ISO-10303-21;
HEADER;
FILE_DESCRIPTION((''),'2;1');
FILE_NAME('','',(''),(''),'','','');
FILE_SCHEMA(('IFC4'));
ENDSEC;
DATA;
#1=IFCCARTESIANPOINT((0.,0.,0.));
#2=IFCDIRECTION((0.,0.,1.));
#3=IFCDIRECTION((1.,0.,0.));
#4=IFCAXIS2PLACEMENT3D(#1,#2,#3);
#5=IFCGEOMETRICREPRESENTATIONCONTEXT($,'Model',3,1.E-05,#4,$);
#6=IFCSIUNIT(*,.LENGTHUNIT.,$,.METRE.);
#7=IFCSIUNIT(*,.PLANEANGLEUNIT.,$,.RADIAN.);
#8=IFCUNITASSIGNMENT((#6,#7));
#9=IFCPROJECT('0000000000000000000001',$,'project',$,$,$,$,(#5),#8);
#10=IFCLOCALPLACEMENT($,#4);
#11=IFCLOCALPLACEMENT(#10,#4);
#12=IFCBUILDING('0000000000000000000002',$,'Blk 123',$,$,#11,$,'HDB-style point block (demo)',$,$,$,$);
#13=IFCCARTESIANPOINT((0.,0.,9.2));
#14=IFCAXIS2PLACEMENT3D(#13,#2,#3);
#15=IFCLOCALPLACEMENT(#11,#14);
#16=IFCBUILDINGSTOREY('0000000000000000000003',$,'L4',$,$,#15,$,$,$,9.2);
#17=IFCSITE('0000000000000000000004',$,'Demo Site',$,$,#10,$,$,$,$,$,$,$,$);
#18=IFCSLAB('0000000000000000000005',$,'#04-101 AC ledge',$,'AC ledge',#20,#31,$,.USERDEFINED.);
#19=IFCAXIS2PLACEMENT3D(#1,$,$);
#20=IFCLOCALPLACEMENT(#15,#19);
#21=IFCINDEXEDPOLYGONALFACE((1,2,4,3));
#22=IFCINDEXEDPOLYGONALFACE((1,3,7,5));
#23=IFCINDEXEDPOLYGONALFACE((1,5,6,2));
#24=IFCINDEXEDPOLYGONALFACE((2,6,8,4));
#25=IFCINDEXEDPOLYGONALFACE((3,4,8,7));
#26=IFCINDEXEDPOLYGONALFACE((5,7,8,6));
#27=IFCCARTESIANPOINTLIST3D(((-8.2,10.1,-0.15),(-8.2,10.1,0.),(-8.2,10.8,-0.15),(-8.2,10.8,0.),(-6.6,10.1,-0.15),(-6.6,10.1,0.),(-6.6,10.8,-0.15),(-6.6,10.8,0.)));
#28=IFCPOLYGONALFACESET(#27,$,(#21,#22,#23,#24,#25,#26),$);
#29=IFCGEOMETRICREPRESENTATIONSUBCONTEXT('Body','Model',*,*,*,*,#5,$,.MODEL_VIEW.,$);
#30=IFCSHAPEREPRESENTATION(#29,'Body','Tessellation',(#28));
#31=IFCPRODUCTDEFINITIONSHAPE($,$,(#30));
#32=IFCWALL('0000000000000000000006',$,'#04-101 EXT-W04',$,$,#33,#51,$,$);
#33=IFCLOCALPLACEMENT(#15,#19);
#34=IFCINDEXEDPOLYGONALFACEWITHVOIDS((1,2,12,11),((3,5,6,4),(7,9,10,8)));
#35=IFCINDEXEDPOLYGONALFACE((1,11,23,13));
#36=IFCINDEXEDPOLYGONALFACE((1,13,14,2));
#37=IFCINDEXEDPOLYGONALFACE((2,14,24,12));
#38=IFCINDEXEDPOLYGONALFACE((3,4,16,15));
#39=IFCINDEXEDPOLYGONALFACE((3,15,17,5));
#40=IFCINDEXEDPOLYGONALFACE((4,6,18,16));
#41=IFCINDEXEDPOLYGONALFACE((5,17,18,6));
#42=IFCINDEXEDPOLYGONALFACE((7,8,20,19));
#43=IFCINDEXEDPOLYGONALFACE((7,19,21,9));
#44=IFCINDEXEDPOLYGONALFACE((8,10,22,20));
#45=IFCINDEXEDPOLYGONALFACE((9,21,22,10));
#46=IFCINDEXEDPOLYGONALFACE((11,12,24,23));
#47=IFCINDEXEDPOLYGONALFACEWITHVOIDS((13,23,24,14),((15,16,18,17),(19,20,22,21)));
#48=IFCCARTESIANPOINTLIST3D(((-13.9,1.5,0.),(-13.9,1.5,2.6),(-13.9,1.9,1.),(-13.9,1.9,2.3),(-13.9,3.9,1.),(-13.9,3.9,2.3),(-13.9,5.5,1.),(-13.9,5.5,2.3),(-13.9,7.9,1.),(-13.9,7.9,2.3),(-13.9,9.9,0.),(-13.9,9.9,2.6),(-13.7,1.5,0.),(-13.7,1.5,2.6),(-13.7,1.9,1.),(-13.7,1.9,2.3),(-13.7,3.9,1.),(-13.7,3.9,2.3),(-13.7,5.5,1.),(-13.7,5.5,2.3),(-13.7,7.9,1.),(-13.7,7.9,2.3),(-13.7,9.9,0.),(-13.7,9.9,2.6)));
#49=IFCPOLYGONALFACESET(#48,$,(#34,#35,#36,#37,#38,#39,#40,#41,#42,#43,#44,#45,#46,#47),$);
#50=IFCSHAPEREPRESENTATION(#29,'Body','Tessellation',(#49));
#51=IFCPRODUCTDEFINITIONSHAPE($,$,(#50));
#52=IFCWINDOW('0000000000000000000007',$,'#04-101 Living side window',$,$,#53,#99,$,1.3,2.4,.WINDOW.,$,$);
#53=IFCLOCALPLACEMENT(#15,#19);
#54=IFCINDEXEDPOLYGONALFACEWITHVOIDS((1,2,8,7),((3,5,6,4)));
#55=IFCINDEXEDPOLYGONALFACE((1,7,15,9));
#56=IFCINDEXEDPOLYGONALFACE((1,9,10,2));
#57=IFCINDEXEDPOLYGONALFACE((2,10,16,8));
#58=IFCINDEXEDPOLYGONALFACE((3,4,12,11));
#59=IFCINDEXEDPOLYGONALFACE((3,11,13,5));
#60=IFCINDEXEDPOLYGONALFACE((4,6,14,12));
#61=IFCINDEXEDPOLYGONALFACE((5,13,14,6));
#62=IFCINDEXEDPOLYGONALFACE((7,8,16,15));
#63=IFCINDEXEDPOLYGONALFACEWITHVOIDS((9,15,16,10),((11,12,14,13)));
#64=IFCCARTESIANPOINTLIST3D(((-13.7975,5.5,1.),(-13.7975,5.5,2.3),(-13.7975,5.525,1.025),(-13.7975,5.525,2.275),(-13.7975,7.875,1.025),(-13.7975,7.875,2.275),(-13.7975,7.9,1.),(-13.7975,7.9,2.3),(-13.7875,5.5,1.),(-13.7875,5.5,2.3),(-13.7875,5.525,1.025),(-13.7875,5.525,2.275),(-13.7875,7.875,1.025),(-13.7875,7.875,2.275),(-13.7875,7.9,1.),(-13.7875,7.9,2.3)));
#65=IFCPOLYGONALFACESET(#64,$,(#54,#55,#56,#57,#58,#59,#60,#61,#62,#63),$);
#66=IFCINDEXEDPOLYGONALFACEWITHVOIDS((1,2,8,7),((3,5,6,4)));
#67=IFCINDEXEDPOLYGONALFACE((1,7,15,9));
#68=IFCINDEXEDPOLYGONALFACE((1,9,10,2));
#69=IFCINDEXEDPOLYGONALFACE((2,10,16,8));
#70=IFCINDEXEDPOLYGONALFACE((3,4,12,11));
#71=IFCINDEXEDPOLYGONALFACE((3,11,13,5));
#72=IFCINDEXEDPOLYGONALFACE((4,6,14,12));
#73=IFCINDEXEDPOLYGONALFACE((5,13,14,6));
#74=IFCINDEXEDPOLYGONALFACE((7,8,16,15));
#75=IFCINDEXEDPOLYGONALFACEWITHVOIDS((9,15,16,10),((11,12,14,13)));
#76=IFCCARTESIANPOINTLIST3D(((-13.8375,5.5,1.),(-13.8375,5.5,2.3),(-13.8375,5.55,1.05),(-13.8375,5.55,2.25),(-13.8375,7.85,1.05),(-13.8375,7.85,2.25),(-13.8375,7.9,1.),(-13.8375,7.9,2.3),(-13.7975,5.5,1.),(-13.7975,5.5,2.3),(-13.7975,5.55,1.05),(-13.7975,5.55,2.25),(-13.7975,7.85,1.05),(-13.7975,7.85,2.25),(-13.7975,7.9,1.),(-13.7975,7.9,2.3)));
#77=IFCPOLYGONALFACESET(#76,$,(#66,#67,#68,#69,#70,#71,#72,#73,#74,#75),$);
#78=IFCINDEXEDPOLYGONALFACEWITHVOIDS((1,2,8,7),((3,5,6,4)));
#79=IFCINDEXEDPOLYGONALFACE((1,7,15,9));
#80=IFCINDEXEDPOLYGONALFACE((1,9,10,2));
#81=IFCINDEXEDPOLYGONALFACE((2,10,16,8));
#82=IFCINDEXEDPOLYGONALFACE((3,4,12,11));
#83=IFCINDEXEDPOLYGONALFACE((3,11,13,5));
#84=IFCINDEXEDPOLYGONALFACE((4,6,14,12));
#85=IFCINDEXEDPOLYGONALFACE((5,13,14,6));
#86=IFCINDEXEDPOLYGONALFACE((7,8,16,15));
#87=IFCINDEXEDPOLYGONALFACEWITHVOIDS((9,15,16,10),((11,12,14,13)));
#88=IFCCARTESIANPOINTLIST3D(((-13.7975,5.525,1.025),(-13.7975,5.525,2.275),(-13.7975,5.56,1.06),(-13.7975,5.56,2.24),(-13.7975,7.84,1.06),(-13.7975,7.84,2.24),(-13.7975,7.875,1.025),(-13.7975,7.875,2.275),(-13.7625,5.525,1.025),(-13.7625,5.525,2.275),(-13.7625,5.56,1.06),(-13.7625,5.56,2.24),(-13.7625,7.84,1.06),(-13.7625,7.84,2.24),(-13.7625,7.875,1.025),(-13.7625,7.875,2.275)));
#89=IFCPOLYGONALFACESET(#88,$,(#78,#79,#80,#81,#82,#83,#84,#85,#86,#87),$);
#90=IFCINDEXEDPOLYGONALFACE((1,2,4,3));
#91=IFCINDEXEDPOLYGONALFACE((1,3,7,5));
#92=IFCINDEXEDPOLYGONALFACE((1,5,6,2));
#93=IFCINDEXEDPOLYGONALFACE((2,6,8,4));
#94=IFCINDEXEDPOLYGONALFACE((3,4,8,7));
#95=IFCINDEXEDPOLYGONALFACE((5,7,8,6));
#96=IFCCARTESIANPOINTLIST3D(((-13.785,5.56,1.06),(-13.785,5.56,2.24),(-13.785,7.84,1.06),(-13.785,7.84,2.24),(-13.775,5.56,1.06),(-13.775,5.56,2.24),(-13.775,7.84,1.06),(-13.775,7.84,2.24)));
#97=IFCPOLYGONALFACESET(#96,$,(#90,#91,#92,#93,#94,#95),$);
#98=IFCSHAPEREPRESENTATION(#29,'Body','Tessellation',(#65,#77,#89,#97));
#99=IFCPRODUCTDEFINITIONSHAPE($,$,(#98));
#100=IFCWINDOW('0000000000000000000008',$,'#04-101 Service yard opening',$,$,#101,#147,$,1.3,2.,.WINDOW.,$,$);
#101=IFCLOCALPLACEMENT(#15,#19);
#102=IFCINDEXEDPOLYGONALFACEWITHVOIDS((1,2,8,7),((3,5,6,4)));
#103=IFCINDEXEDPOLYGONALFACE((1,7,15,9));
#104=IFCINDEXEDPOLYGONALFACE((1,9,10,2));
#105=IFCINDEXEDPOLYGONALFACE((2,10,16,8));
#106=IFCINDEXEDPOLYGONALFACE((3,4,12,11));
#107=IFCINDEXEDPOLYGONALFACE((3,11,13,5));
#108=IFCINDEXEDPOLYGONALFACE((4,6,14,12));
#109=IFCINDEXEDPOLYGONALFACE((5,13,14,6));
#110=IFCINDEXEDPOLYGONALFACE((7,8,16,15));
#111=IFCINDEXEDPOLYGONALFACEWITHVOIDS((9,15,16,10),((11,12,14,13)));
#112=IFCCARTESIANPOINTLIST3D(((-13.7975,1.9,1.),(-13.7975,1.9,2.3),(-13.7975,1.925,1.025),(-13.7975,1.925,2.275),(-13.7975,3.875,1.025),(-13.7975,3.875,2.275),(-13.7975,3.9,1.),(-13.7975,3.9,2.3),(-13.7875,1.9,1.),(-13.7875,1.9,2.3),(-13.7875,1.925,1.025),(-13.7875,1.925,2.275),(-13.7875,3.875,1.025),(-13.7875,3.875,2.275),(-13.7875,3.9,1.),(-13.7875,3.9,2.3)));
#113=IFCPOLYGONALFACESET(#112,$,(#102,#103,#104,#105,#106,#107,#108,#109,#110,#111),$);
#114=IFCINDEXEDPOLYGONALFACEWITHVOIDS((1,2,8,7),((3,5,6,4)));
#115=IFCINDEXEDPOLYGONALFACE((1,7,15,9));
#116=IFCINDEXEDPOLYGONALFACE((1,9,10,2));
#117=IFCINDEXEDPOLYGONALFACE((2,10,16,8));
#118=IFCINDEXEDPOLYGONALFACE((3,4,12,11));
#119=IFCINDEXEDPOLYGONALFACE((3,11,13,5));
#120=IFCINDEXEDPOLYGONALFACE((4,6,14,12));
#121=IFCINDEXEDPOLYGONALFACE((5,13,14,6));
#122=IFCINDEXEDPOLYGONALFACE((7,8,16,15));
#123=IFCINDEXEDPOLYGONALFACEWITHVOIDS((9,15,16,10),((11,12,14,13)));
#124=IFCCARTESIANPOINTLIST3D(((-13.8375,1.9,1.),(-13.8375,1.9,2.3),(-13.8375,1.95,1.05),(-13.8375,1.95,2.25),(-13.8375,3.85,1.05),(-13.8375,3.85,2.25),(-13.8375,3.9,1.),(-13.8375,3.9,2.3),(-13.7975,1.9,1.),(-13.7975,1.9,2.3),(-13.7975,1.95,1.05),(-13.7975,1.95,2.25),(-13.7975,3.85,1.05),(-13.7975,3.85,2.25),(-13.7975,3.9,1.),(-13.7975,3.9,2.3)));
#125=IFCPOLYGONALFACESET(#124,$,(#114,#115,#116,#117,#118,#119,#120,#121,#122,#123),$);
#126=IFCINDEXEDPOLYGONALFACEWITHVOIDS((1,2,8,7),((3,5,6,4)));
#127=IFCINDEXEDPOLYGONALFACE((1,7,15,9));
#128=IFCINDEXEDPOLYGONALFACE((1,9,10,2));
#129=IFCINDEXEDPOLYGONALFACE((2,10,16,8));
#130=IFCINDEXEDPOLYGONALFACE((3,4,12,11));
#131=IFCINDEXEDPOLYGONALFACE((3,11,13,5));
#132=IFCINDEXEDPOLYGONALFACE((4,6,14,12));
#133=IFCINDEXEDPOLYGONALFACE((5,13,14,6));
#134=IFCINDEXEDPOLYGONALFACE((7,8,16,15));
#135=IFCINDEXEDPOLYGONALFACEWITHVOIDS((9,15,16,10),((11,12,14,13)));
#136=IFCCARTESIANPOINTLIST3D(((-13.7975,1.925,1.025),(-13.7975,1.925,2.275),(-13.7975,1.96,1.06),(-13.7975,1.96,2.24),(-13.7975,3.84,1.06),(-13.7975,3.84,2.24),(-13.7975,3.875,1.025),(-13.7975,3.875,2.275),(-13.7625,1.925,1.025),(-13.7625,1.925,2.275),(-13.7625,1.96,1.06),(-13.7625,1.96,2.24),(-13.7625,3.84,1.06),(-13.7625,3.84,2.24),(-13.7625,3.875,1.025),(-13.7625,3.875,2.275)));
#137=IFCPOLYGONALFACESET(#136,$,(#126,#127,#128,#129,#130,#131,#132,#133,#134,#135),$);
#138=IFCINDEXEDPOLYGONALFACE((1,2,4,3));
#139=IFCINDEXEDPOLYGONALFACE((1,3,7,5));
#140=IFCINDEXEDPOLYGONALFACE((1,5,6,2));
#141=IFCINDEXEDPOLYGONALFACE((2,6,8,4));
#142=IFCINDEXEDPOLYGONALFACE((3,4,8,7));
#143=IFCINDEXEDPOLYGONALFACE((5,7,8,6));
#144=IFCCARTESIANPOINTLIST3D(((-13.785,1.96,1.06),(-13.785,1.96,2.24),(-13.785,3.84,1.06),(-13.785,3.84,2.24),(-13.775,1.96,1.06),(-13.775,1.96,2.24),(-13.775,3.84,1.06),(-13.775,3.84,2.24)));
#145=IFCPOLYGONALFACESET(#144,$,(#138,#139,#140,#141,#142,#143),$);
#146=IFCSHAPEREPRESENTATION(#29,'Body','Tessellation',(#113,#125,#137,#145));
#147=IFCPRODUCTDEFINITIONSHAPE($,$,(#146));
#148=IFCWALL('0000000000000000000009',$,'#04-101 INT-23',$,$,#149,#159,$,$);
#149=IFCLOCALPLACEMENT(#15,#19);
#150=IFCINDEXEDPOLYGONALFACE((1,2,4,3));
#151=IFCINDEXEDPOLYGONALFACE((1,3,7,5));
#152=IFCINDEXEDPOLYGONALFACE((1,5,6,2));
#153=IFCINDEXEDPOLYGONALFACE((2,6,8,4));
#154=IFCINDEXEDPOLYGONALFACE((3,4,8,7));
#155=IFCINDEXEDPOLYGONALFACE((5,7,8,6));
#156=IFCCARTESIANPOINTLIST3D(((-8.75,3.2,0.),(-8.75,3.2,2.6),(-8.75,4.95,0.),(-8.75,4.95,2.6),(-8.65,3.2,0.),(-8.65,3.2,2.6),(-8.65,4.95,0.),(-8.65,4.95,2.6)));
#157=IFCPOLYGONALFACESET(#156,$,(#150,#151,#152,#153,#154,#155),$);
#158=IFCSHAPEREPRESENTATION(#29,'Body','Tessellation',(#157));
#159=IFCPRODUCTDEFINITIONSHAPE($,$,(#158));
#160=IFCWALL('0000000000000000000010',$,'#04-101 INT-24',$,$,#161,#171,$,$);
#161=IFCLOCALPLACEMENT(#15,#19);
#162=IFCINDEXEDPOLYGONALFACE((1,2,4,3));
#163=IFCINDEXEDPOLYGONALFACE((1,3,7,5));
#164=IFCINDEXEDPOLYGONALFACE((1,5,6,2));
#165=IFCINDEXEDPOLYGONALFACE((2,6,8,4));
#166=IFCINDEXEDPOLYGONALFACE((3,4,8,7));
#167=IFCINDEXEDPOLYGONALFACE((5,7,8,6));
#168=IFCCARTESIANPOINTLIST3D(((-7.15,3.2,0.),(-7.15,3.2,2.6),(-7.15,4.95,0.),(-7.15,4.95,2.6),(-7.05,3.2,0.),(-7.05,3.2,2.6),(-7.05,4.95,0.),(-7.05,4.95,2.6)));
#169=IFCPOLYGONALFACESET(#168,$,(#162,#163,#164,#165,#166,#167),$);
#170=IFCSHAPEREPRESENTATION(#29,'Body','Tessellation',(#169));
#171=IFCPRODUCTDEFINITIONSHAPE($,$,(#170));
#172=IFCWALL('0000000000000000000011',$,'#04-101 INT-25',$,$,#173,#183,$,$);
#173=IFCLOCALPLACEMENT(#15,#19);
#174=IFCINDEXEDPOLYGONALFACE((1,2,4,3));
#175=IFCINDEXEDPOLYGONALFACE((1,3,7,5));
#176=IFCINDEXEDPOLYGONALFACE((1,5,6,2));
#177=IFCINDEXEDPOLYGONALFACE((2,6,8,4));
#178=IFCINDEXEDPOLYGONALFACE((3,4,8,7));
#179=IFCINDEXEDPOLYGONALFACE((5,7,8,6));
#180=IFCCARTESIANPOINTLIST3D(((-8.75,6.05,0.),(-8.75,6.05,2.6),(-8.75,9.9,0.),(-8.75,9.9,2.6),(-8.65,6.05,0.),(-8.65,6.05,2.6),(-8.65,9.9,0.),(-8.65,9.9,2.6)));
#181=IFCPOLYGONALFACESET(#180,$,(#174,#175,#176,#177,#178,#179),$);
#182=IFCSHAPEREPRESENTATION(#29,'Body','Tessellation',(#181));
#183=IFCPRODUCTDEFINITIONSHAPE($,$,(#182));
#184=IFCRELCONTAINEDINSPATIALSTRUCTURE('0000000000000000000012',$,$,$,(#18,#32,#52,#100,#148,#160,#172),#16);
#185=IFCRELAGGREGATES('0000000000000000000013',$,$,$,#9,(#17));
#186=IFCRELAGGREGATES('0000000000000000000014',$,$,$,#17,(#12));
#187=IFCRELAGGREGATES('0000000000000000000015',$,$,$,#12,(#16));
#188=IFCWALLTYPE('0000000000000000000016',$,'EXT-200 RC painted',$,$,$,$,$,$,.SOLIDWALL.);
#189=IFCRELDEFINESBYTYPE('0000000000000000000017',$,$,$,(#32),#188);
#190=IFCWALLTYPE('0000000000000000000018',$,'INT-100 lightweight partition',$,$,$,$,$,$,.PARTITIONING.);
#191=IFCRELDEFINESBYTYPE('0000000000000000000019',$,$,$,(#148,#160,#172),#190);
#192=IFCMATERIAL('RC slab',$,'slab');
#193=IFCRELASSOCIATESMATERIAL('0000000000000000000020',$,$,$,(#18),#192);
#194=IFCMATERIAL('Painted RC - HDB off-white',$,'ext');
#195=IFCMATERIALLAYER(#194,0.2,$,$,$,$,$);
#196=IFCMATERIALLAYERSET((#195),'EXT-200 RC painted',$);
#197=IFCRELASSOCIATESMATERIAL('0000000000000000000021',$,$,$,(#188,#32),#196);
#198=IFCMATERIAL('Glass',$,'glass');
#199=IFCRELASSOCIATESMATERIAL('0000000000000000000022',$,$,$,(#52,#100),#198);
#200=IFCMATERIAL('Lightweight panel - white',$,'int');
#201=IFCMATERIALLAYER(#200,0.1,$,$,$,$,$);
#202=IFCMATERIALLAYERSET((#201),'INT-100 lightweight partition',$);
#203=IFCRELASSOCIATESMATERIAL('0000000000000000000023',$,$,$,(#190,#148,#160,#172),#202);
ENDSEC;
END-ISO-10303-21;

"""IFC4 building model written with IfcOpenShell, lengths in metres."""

from ifc_helpers import new_model, si_unit, frame, origin, origin_with_axes, place, context, subcontext, project, spatial, polyline, line, indexed_curve, outline, extrude, material, layer, layer_set, layer_usage, type_object, element, fill, save


model = new_model("IFC4")

# Units and contexts
model_context = context("Model", 3, precision=1e-05, world=origin_with_axes())
body_context = subcontext(model_context, "Body", "Model", "MODEL_VIEW")
ifc_project = project(units=[si_unit("LENGTHUNIT", "METRE"), si_unit("PLANEANGLEUNIT", "RADIAN")], contexts=[model_context])

# Site, building, storey
site_placement = place(None, origin_with_axes())
site = spatial("IfcSite", under=ifc_project, at=site_placement, Name="Demo Site")
building_placement = place(site_placement, origin_with_axes())
building = spatial("IfcBuilding", under=site, at=building_placement, Name="Blk 123", LongName="HDB-style point block (demo)")
storey_placement = place(building_placement, frame((0.0, 0.0, 9.2), z_axis=(0.0, 0.0, 1.0), x_axis=(1.0, 0.0, 0.0)))
storey = spatial("IfcBuildingStorey", under=building, at=storey_placement, Name="L4", Elevation=9.2)

# Slab
ifc_material_1 = material(Name="RC slab", Category="slab")
slab_placement = place(storey_placement, frame((-7.4, 10.45, -0.15), z_axis=(0.0, 0.0, 1.0), x_axis=(1.0, 0.0, 0.0)))
element("IfcSlab", 1, at=slab_placement, inside=storey, material=ifc_material_1, Name="#04-101 AC ledge", ObjectType="AC ledge", PredefinedType="USERDEFINED", context=body_context, shape_type="SweptSolid", body=[
    extrude(outline(polyline([(-0.8, -0.35), (0.8, -0.35), (0.8, 0.35), (-0.8, 0.35), (-0.8, -0.35)])), origin(), (0.0, 0.0, 1.0), 0.15),
])

# Shared definitions
ifc_material_2 = material(Name="Painted RC - HDB off-white", Category="ext")
ifc_layer_1 = layer(ifc_material_2, 0.2)
ifc_layer_set_1 = layer_set([ifc_layer_1], Name="EXT-200 RC painted")
ifc_layer_usage_1 = layer_usage(ifc_layer_set_1, "AXIS2", "POSITIVE", 0.0)
wall_type_1 = type_object("IfcWallType", Name="EXT-200 RC painted", PredefinedType="SOLIDWALL", material=ifc_layer_set_1)
ifc_material_3 = material(Name="Glass", Category="glass")

# Wall, openings, windows
wall_1_placement = place(storey_placement, frame((-13.9, 9.9, 0.0), z_axis=(0.0, 0.0, 1.0), x_axis=(0.0, -1.0, 0.0)))
wall_1 = element("IfcWall", 2, at=wall_1_placement, inside=storey, type_object=wall_type_1, material=ifc_layer_usage_1, Name="#04-101 EXT-W04", context=body_context, shape_type="SweptSolid", body=[
    extrude(outline(indexed_curve([(0.0, 0.0), (0.0, 0.2), (8.4, 0.2), (8.4, 0.0), (0.0, 0.0)], self_intersect=False)), origin_with_axes(), (0.0, 0.0, 1.0), 2.6),
])
opening_1_placement = place(wall_1_placement, frame((2.0, -0.1, 1.0), z_axis=(0.0, 0.0, 1.0), x_axis=(1.0, 0.0, 0.0)))
opening_1 = element("IfcOpeningElement", 3, at=opening_1_placement, cuts=wall_1, context=body_context, shape_type="SweptSolid", body=[
    extrude(outline(indexed_curve([(0.0, 0.0), (0.0, 0.4), (2.4, 0.4), (2.4, 0.0), (0.0, 0.0)], self_intersect=False)), origin_with_axes(), (0.0, 0.0, 1.0), 1.3),
])
opening_2_placement = place(wall_1_placement, frame((6.0, -0.1, 1.0), z_axis=(0.0, 0.0, 1.0), x_axis=(1.0, 0.0, 0.0)))
opening_2 = element("IfcOpeningElement", 4, at=opening_2_placement, cuts=wall_1, context=body_context, shape_type="SweptSolid", body=[
    extrude(outline(indexed_curve([(0.0, 0.0), (0.0, 0.4), (2.0, 0.4), (2.0, 0.0), (0.0, 0.0)], self_intersect=False)), origin_with_axes(), (0.0, 0.0, 1.0), 1.3),
])
window_1_placement = place(opening_1_placement, frame((0.0, 0.1125, 0.0), z_axis=(0.0, 0.0, 1.0), x_axis=(1.0, 0.0, 0.0)))
window_1 = element("IfcWindow", 5, at=window_1_placement, inside=storey, material=ifc_material_3, Name="#04-101 Living side window", OverallHeight=1.3, OverallWidth=2.4, PredefinedType="WINDOW", context=body_context, shape_type="SweptSolid", body=[
    extrude(outline(indexed_curve([(0.0, 0.0), (2.4, 0.0), (2.4, 1.3), (0.0, 1.3)], segments=[line(1, 2, 3, 4, 1)]), holes=[indexed_curve([(0.025, 0.025), (2.375, 0.025), (2.375, 1.275), (0.025, 1.275)], segments=[line(1, 2, 3, 4, 1)])]), frame((0.0, 0.09, 0.0), z_axis=(0.0, -1.0, 0.0), x_axis=(1.0, 0.0, 0.0)), (0.0, 0.0, -1.0), 0.01),
    extrude(outline(indexed_curve([(0.0, 0.0), (2.4, 0.0), (2.4, 1.3), (0.0, 1.3)], segments=[line(1, 2, 3, 4, 1)]), holes=[indexed_curve([(0.05, 0.05), (2.35, 0.05), (2.35, 1.25), (0.05, 1.25)], segments=[line(1, 2, 3, 4, 1)])]), frame((0.0, 0.05, 0.0), z_axis=(0.0, -1.0, 0.0), x_axis=(1.0, 0.0, 0.0)), (0.0, 0.0, -1.0), 0.04),
    extrude(outline(indexed_curve([(0.0, 0.0), (2.35, 0.0), (2.35, 1.25), (0.0, 1.25)], segments=[line(1, 2, 3, 4, 1)]), holes=[indexed_curve([(0.035, 0.035), (2.315, 0.035), (2.315, 1.215), (0.035, 1.215)], segments=[line(1, 2, 3, 4, 1)])]), frame((0.025, 0.09, 0.025), z_axis=(0.0, -1.0, 0.0), x_axis=(1.0, 0.0, 0.0)), (0.0, 0.0, -1.0), 0.035),
    extrude(outline(indexed_curve([(0.035, 0.035), (2.315, 0.035), (2.315, 1.215), (0.035, 1.215)], segments=[line(1, 2, 3, 4, 1)])), frame((0.025, 0.1025, 0.025), z_axis=(0.0, -1.0, 0.0), x_axis=(1.0, 0.0, 0.0)), (0.0, 0.0, -1.0), 0.01),
])
fill(opening_1, window_1)
window_2_placement = place(opening_2_placement, frame((0.0, 0.1125, 0.0), z_axis=(0.0, 0.0, 1.0), x_axis=(1.0, 0.0, 0.0)))
window_2 = element("IfcWindow", 6, at=window_2_placement, inside=storey, material=ifc_material_3, Name="#04-101 Service yard opening", OverallHeight=1.3, OverallWidth=2.0, PredefinedType="WINDOW", context=body_context, shape_type="SweptSolid", body=[
    extrude(outline(indexed_curve([(0.0, 0.0), (2.0, 0.0), (2.0, 1.3), (0.0, 1.3)], segments=[line(1, 2, 3, 4, 1)]), holes=[indexed_curve([(0.025, 0.025), (1.975, 0.025), (1.975, 1.275), (0.025, 1.275)], segments=[line(1, 2, 3, 4, 1)])]), frame((0.0, 0.09, 0.0), z_axis=(0.0, -1.0, 0.0), x_axis=(1.0, 0.0, 0.0)), (0.0, 0.0, -1.0), 0.01),
    extrude(outline(indexed_curve([(0.0, 0.0), (2.0, 0.0), (2.0, 1.3), (0.0, 1.3)], segments=[line(1, 2, 3, 4, 1)]), holes=[indexed_curve([(0.05, 0.05), (1.95, 0.05), (1.95, 1.25), (0.05, 1.25)], segments=[line(1, 2, 3, 4, 1)])]), frame((0.0, 0.05, 0.0), z_axis=(0.0, -1.0, 0.0), x_axis=(1.0, 0.0, 0.0)), (0.0, 0.0, -1.0), 0.04),
    extrude(outline(indexed_curve([(0.0, 0.0), (1.95, 0.0), (1.95, 1.25), (0.0, 1.25)], segments=[line(1, 2, 3, 4, 1)]), holes=[indexed_curve([(0.035, 0.035), (1.915, 0.035), (1.915, 1.215), (0.035, 1.215)], segments=[line(1, 2, 3, 4, 1)])]), frame((0.025, 0.09, 0.025), z_axis=(0.0, -1.0, 0.0), x_axis=(1.0, 0.0, 0.0)), (0.0, 0.0, -1.0), 0.035),
    extrude(outline(indexed_curve([(0.035, 0.035), (1.915, 0.035), (1.915, 1.215), (0.035, 1.215)], segments=[line(1, 2, 3, 4, 1)])), frame((0.025, 0.1025, 0.025), z_axis=(0.0, -1.0, 0.0), x_axis=(1.0, 0.0, 0.0)), (0.0, 0.0, -1.0), 0.01),
])
fill(opening_2, window_2)

# Walls
ifc_material_4 = material(Name="Lightweight panel - white", Category="int")
ifc_layer_2 = layer(ifc_material_4, 0.1)
ifc_layer_set_2 = layer_set([ifc_layer_2], Name="INT-100 lightweight partition")
ifc_layer_usage_2 = layer_usage(ifc_layer_set_2, "AXIS2", "POSITIVE", -0.05)
wall_type_2 = type_object("IfcWallType", Name="INT-100 lightweight partition", PredefinedType="PARTITIONING", material=ifc_layer_set_2)
for number, where, z_axis, x_axis, name in (
    (7, (-8.7, 3.2, 0.0), (0.0, 0.0, 1.0), (0.0, 1.0, 0.0), "#04-101 INT-23"),
    (8, (-7.1, 3.2, 0.0), (0.0, 0.0, 1.0), (0.0, 1.0, 0.0), "#04-101 INT-24"),
):
    element("IfcWall", number, at=place(storey_placement, frame(where, z_axis=z_axis, x_axis=x_axis)), inside=storey, type_object=wall_type_2, material=ifc_layer_usage_2, Name=name, context=body_context, shape_type="SweptSolid", body=[
        extrude(outline(indexed_curve([(0.0, 0.0), (0.0, 0.1), (1.75, 0.1), (1.75, 0.0), (0.0, 0.0)], self_intersect=False)), frame((0.0, -0.05, 0.0), z_axis=(0.0, 0.0, 1.0), x_axis=(1.0, 0.0, 0.0)), (0.0, 0.0, 1.0), 2.6),
    ])
wall_2_placement = place(storey_placement, frame((-8.7, 6.05, 0.0), z_axis=(0.0, 0.0, 1.0), x_axis=(0.0, 1.0, 0.0)))
element("IfcWall", 9, at=wall_2_placement, inside=storey, type_object=wall_type_2, material=ifc_layer_usage_2, Name="#04-101 INT-25", context=body_context, shape_type="SweptSolid", body=[
    extrude(outline(indexed_curve([(0.0, 0.0), (0.0, 0.1), (3.85, 0.1), (3.85, 0.0), (0.0, 0.0)], self_intersect=False)), frame((0.0, -0.05, 0.0), z_axis=(0.0, 0.0, 1.0), x_axis=(1.0, 0.0, 0.0)), (0.0, 0.0, 1.0), 2.6),
])

save(model, "model.ifc")
